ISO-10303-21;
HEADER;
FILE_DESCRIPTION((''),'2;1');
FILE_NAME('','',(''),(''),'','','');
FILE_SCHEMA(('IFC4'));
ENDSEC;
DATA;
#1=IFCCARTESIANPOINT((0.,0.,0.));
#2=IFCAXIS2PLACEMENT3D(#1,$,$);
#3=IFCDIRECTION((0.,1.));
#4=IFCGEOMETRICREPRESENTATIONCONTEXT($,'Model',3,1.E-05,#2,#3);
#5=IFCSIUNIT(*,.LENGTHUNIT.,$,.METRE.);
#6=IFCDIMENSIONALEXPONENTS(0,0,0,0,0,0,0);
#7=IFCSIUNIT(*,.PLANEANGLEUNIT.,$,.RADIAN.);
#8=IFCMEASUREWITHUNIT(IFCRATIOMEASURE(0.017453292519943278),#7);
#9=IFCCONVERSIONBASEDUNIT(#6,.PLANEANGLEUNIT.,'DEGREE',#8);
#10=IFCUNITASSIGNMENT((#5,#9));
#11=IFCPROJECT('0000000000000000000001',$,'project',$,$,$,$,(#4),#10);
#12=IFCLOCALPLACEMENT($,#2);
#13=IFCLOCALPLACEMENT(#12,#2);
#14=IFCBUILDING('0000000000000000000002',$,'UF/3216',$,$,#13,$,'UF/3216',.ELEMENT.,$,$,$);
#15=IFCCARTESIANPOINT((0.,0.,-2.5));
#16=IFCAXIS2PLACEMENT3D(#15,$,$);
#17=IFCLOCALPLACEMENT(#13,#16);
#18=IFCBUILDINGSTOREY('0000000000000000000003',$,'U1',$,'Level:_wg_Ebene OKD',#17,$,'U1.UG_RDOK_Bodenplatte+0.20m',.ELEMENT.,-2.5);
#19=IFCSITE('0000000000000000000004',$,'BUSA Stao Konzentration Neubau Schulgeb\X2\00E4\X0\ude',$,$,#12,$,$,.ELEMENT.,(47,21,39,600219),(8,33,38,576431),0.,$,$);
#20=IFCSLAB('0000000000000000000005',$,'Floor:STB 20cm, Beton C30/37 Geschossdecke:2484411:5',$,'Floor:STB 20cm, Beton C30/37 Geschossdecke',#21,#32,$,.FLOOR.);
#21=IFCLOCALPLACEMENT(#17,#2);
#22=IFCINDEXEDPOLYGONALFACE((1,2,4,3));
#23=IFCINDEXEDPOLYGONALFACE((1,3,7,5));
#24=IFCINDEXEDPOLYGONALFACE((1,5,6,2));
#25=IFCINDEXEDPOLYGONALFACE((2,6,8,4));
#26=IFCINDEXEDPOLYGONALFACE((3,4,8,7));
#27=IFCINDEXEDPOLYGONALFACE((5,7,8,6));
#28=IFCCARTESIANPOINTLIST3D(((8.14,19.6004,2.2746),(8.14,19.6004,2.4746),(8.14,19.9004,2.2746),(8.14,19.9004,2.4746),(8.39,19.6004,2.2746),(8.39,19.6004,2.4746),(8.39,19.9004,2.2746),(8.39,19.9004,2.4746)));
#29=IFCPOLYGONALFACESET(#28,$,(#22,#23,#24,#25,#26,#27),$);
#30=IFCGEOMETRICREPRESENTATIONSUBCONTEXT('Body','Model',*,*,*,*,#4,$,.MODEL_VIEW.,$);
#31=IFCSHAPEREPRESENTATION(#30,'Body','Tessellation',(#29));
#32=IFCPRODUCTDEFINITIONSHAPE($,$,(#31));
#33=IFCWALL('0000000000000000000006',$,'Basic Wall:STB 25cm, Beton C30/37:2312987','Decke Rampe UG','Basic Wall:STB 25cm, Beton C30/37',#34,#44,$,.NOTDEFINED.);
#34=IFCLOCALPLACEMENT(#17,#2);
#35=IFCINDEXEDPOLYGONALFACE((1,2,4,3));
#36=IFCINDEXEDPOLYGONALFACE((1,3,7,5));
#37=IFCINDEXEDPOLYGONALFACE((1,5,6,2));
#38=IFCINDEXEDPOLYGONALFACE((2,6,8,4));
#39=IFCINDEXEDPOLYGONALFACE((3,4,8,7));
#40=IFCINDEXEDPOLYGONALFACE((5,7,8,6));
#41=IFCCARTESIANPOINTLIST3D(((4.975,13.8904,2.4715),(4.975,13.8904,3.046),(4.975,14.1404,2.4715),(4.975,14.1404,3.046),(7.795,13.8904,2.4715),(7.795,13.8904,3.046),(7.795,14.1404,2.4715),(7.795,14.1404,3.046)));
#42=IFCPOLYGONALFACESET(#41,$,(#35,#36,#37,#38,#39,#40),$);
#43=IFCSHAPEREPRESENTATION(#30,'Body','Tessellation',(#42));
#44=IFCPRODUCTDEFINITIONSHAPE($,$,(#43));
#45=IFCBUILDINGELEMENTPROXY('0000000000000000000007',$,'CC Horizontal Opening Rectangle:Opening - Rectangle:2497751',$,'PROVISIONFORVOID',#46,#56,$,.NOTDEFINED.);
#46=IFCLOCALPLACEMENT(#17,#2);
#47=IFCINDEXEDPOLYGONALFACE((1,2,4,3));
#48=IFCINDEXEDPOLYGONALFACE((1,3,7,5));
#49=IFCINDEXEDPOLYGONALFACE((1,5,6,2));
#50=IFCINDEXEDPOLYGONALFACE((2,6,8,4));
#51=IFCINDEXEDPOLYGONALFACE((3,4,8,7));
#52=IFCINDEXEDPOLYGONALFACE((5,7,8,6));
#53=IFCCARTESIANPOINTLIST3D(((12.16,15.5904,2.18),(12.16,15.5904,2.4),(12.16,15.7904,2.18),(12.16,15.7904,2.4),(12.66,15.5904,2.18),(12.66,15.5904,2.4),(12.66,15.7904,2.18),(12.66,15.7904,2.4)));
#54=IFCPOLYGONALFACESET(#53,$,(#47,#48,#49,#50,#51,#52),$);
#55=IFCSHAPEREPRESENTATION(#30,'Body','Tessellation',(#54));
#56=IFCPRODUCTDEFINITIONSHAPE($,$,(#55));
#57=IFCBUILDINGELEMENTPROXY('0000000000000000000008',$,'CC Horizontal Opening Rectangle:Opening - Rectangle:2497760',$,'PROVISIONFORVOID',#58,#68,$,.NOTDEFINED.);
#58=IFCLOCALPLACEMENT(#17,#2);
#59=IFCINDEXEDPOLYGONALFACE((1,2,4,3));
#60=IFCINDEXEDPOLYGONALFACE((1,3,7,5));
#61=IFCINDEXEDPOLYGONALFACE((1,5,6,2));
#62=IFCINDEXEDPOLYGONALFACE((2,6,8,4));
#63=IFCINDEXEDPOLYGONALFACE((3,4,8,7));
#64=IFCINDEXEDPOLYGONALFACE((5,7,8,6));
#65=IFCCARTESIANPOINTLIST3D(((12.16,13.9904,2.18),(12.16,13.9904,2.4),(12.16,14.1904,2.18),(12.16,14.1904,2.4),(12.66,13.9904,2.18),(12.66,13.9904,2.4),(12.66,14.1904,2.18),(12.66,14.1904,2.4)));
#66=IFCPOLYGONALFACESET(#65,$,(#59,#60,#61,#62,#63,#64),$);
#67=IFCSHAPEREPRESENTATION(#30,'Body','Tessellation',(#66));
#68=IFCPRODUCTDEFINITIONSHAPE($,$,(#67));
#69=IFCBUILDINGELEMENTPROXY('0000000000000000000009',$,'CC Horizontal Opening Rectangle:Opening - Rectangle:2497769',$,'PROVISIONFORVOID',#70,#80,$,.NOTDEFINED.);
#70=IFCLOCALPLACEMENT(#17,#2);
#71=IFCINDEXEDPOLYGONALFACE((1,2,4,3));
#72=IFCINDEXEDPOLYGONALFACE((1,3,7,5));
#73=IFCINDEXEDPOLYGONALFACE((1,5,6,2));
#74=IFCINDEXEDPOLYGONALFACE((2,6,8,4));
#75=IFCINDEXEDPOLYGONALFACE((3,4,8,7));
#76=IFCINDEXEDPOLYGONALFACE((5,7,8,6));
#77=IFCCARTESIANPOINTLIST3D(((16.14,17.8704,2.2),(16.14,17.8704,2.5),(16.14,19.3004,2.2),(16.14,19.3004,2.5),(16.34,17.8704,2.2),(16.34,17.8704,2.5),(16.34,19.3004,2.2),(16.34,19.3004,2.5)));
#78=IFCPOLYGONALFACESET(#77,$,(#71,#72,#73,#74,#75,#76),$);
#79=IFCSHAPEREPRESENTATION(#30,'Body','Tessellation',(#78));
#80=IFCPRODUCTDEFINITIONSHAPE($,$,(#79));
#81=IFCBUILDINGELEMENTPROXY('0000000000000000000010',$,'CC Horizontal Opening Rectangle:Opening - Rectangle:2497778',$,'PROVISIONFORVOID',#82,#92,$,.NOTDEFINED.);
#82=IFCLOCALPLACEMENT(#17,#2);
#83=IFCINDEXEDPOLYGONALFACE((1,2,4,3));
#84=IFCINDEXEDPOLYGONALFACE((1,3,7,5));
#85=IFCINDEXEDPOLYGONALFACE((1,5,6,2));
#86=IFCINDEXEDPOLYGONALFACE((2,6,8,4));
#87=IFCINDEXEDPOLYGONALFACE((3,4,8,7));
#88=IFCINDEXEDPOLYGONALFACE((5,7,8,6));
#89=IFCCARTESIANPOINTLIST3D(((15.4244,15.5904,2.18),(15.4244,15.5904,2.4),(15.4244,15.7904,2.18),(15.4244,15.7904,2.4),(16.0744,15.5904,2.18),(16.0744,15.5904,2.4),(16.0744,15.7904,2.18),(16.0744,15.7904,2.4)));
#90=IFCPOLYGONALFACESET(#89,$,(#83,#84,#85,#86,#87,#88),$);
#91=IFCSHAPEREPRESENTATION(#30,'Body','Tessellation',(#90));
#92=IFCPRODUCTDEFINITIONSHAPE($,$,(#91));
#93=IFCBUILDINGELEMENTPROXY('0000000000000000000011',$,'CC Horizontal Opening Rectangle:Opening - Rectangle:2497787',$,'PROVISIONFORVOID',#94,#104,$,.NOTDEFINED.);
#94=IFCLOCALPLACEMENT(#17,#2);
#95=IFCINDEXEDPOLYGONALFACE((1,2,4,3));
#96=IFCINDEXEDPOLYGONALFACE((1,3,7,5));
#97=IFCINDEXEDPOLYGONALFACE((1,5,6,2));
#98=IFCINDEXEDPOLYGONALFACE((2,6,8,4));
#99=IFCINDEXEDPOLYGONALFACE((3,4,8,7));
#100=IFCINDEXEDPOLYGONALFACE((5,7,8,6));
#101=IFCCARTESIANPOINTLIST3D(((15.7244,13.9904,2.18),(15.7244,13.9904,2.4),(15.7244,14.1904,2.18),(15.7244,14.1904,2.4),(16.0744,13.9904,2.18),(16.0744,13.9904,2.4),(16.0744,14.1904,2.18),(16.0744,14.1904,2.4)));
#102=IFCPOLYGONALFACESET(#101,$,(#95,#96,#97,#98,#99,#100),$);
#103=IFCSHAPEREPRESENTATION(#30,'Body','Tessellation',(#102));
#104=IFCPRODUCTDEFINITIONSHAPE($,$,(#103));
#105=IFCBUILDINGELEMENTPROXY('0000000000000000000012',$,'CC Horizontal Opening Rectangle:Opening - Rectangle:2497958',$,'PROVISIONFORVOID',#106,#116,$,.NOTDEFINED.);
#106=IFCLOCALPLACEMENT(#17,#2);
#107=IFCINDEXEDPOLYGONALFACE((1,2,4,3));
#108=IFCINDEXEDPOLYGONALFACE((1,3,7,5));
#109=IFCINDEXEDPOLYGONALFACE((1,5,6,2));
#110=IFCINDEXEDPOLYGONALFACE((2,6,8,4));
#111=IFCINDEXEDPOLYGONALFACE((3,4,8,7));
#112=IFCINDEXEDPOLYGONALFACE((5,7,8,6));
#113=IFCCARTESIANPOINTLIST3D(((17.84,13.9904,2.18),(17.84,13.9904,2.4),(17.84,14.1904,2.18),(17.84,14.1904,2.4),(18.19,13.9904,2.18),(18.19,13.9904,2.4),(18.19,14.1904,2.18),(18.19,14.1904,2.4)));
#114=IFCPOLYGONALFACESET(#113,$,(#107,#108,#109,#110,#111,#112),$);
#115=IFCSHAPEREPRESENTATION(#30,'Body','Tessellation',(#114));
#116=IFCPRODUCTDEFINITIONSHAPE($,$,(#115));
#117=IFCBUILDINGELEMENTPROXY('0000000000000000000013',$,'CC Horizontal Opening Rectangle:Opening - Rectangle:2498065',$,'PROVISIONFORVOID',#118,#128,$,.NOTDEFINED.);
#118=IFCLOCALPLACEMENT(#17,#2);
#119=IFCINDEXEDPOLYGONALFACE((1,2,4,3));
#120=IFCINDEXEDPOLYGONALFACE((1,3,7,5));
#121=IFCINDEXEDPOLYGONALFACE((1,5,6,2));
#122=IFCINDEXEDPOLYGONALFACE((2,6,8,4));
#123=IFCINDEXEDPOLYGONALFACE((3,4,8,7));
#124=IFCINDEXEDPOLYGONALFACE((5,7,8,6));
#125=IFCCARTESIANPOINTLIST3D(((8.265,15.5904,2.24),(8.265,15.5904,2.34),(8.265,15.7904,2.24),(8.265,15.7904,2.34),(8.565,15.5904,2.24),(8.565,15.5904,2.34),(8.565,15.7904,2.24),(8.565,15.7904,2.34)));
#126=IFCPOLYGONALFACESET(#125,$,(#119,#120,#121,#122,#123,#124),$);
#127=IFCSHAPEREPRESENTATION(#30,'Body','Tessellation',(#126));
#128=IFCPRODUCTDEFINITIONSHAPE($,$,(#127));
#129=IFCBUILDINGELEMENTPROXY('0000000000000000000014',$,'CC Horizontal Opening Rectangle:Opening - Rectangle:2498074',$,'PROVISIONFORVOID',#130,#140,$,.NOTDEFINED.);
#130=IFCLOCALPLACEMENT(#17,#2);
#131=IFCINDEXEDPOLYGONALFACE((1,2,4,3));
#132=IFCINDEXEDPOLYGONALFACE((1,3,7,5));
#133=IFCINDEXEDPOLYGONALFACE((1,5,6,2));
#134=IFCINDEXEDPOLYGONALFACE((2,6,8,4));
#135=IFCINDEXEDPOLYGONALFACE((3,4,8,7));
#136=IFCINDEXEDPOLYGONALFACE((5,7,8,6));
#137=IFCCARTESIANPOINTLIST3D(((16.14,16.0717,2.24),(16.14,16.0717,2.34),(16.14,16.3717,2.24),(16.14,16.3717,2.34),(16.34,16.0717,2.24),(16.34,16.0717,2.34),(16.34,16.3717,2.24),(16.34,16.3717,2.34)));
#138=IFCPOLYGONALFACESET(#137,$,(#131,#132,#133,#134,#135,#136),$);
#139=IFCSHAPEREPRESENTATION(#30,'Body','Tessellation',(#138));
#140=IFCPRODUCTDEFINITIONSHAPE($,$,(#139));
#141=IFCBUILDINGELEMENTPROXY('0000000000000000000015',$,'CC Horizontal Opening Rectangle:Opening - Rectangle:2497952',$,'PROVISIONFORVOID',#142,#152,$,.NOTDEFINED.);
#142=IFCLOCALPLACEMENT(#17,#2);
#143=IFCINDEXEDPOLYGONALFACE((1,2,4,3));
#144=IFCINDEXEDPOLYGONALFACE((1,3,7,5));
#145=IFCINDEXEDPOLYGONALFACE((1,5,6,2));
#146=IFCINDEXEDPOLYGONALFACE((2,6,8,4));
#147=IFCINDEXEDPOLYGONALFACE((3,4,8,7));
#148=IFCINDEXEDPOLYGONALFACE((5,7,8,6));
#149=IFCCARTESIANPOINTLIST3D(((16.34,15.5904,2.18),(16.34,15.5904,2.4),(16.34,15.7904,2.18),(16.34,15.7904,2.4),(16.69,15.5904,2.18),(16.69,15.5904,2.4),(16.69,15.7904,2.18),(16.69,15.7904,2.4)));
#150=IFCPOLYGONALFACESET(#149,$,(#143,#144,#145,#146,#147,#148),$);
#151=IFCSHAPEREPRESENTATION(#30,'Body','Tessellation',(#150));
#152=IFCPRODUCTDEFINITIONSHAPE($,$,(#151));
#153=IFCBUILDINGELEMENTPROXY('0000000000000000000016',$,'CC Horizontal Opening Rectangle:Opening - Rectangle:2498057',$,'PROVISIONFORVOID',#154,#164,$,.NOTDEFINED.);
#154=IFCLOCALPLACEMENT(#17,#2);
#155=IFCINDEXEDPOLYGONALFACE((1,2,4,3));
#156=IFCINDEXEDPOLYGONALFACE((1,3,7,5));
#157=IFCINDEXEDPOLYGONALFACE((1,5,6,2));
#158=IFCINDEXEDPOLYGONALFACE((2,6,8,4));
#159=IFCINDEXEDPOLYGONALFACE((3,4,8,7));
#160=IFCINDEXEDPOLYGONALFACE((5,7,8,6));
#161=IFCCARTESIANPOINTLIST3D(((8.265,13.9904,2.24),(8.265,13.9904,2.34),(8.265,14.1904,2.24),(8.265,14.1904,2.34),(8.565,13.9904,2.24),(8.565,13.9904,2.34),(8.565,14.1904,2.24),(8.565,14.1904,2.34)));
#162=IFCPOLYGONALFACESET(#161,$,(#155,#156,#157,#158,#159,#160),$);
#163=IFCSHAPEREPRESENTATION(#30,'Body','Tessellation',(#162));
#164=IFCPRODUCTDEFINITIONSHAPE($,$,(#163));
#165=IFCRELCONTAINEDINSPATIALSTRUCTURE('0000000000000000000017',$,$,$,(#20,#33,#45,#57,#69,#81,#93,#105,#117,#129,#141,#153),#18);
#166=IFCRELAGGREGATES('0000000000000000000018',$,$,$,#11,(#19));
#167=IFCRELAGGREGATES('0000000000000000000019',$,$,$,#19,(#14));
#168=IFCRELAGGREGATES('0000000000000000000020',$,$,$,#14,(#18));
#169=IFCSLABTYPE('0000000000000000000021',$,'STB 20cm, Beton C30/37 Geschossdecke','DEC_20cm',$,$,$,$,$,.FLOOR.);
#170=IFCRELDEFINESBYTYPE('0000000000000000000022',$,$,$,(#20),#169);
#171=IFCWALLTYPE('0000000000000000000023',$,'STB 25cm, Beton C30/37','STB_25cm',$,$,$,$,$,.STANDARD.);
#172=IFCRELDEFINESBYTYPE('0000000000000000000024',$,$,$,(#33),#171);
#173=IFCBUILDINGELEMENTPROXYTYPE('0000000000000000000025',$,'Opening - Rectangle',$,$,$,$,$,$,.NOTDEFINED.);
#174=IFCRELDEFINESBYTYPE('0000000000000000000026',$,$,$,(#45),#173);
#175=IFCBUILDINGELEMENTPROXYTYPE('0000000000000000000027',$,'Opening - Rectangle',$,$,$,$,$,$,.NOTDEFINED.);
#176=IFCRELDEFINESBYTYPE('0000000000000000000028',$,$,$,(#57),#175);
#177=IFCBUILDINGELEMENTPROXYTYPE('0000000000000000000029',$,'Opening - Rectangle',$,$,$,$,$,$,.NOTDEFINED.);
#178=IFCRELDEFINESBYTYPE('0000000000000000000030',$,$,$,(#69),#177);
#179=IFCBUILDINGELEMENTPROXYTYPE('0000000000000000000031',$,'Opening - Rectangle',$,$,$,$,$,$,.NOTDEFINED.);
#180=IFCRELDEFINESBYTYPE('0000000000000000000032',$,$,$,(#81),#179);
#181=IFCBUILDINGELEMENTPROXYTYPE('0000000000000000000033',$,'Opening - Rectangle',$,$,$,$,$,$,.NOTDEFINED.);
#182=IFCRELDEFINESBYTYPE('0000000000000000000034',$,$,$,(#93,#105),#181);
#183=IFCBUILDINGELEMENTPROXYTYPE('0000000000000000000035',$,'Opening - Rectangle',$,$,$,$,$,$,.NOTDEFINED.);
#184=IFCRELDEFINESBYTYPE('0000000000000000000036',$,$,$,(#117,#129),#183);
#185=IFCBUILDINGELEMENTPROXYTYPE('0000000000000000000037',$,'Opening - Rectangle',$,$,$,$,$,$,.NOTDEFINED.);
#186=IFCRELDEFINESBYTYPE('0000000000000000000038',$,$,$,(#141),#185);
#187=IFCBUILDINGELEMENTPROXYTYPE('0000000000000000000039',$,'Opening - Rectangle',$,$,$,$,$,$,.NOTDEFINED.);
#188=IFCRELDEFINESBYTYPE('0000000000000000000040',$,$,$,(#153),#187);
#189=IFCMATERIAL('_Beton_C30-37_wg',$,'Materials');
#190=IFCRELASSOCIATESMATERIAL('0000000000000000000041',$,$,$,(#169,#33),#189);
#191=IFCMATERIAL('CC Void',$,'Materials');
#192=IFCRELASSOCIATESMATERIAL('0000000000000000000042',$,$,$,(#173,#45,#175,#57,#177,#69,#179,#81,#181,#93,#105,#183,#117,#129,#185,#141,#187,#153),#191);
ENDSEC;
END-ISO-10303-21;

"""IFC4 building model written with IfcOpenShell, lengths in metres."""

from ifc_helpers import new_model, entity, si_unit, converted_unit, direction, frame, frame_2d, origin, place, context, subcontext, project, spatial, indexed_curve, rectangle, outline, extrude, source, transform, mapped, material, type_object, type_shapes, element, save


model = new_model("IFC4")

# Units and contexts
model_context = context("Model", 3, precision=1e-05, world=origin(), true_north=direction((0.0, 1.0)))
body_context = subcontext(model_context, "Body", "Model", "MODEL_VIEW")
ifc_project = project(units=[si_unit("LENGTHUNIT", "METRE"), converted_unit("PLANEANGLEUNIT", "DEGREE", entity("IfcRatioMeasure", 0.017453292519943278), si_unit("PLANEANGLEUNIT", "RADIAN"), dimensions=[0, 0, 0, 0, 0, 0, 0])], contexts=[model_context])

# Site, building, storey
site_placement = place(None, origin())
site = spatial("IfcSite", under=ifc_project, at=site_placement, Name="BUSA Stao Konzentration Neubau Schulgebäude", CompositionType="ELEMENT", RefLatitude=(47, 21, 39, 600219), RefLongitude=(8, 33, 38, 576431), RefElevation=0.0)
building_placement = place(site_placement, origin())
building = spatial("IfcBuilding", under=site, at=building_placement, Name="UF/3216", LongName="UF/3216", CompositionType="ELEMENT")
storey_placement = place(building_placement, frame((0.0, 0.0, -2.5)))
storey = spatial("IfcBuildingStorey", under=building, at=storey_placement, Name="U1", ObjectType="Level:_wg_Ebene OKD", LongName="U1.UG_RDOK_Bodenplatte+0.20m", CompositionType="ELEMENT", Elevation=-2.5)

# Slab
ifc_material_1 = material(Name="_Beton_C30-37_wg", Category="Materials")
slab_type = type_object("IfcSlabType", Name="STB 20cm, Beton C30/37 Geschossdecke", Description="DEC_20cm", PredefinedType="FLOOR", material=ifc_material_1)
slab_1_placement = place(storey_placement, frame((8.14, 19.6004, 2.2746)))
element("IfcSlab", 1, at=slab_1_placement, inside=storey, type_object=slab_type, Name="Floor:STB 20cm, Beton C30/37 Geschossdecke:2484411:5", ObjectType="Floor:STB 20cm, Beton C30/37 Geschossdecke", PredefinedType="FLOOR", context=body_context, shape_type="SweptSolid", body=[
    extrude(rectangle(XDim=0.3, YDim=0.25, at=frame_2d((27.45, 0.0), x_axis=(0.0, -1.0))), frame((27.575, 0.15, 0.2), z_axis=(0.0, 0.0, -1.0), x_axis=(-1.0, 0.0, 0.0)), (0.0, 0.0, 1.0), 0.2),
])

# Wall
wall_type = type_object("IfcWallType", Name="STB 25cm, Beton C30/37", Description="STB_25cm", PredefinedType="STANDARD")
wall_placement = place(storey_placement, frame((7.795, 14.0154, 2.4715), z_axis=(0.0, 0.0, 1.0), x_axis=(-1.0, 0.0, 0.0)))
element("IfcWall", 2, at=wall_placement, inside=storey, type_object=wall_type, material=ifc_material_1, Name="Basic Wall:STB 25cm, Beton C30/37:2312987", Description="Decke Rampe UG", ObjectType="Basic Wall:STB 25cm, Beton C30/37", PredefinedType="NOTDEFINED", context=body_context, shape_type="SweptSolid", body=[
    extrude(outline(indexed_curve([(2.82, 0.125), (0.0, 0.125), (0.0, -0.125), (2.82, -0.125), (2.82, 0.125)], self_intersect=False)), origin(), (0.0, 0.0, 1.0), 0.5746),
])

# Building element proxies
ifc_material_2 = material(Name="CC Void", Category="Materials")
building_element_proxy_type_1 = type_object("IfcBuildingElementProxyType", Name="Opening - Rectangle", PredefinedType="NOTDEFINED", material=ifc_material_2)
shared_shape_1 = source(origin(), body_context, "Body", "SweptSolid", [
    extrude(outline(indexed_curve([(-0.1, -0.25), (0.1, -0.25), (0.1, 0.25), (-0.1, 0.25), (-0.1, -0.25)], self_intersect=False)), frame((0.0, 0.0, -0.32), z_axis=(0.0, 0.0, 1.0), x_axis=(0.0, -1.0, 0.0)), (0.0, 0.0, 1.0), 0.22),
])
type_shapes(building_element_proxy_type_1, [shared_shape_1])
proxy_1_placement = place(storey_placement, frame((12.41, 15.6904, 2.5)))
element("IfcBuildingElementProxy", 3, at=proxy_1_placement, inside=storey, type_object=building_element_proxy_type_1, material=ifc_material_2, Name="CC Horizontal Opening Rectangle:Opening - Rectangle:2497751", ObjectType="PROVISIONFORVOID", PredefinedType="NOTDEFINED", context=body_context, shape_type="MappedRepresentation", body=[
    mapped(shared_shape_1, transform((0.0, 0.0, 0.0), scale=1.0)),
])
building_element_proxy_type_2 = type_object("IfcBuildingElementProxyType", Name="Opening - Rectangle", PredefinedType="NOTDEFINED", material=ifc_material_2)
shared_shape_2 = source(origin(), body_context, "Body", "SweptSolid", [
    extrude(outline(indexed_curve([(-0.1, -0.25), (0.1, -0.25), (0.1, 0.25), (-0.1, 0.25), (-0.1, -0.25)], self_intersect=False)), frame((0.0, 0.0, -0.32), z_axis=(0.0, 0.0, 1.0), x_axis=(0.0, -1.0, 0.0)), (0.0, 0.0, 1.0), 0.22),
])
type_shapes(building_element_proxy_type_2, [shared_shape_2])
proxy_2_placement = place(storey_placement, frame((12.41, 14.0904, 2.5)))
element("IfcBuildingElementProxy", 4, at=proxy_2_placement, inside=storey, type_object=building_element_proxy_type_2, material=ifc_material_2, Name="CC Horizontal Opening Rectangle:Opening - Rectangle:2497760", ObjectType="PROVISIONFORVOID", PredefinedType="NOTDEFINED", context=body_context, shape_type="MappedRepresentation", body=[
    mapped(shared_shape_2, transform((0.0, 0.0, 0.0), scale=1.0)),
])
building_element_proxy_type_3 = type_object("IfcBuildingElementProxyType", Name="Opening - Rectangle", PredefinedType="NOTDEFINED", material=ifc_material_2)
shared_shape_3 = source(origin(), body_context, "Body", "SweptSolid", [
    extrude(outline(indexed_curve([(-0.1, -0.715), (0.1, -0.715), (0.1, 0.715), (-0.1, 0.715), (-0.1, -0.715)], self_intersect=False)), frame((0.0, 0.0, -0.3), z_axis=(0.0, 0.0, 1.0), x_axis=(0.0, -1.0, 0.0)), (0.0, 0.0, 1.0), 0.3),
])
type_shapes(building_element_proxy_type_3, [shared_shape_3])
proxy_3_placement = place(storey_placement, frame((16.24, 18.5854, 2.5), z_axis=(0.0, 0.0, 1.0), x_axis=(0.0, 1.0, 0.0)))
element("IfcBuildingElementProxy", 5, at=proxy_3_placement, inside=storey, type_object=building_element_proxy_type_3, material=ifc_material_2, Name="CC Horizontal Opening Rectangle:Opening - Rectangle:2497769", ObjectType="PROVISIONFORVOID", PredefinedType="NOTDEFINED", context=body_context, shape_type="MappedRepresentation", body=[
    mapped(shared_shape_3, transform((0.0, 0.0, 0.0), scale=1.0)),
])
building_element_proxy_type_4 = type_object("IfcBuildingElementProxyType", Name="Opening - Rectangle", PredefinedType="NOTDEFINED", material=ifc_material_2)
shared_shape_4 = source(origin(), body_context, "Body", "SweptSolid", [
    extrude(outline(indexed_curve([(-0.1, -0.325), (0.1, -0.325), (0.1, 0.325), (-0.1, 0.325), (-0.1, -0.325)], self_intersect=False)), frame((0.0, 0.0, -0.32), z_axis=(0.0, 0.0, 1.0), x_axis=(0.0, -1.0, 0.0)), (0.0, 0.0, 1.0), 0.22),
])
type_shapes(building_element_proxy_type_4, [shared_shape_4])
proxy_4_placement = place(storey_placement, frame((15.7494, 15.6904, 2.5)))
element("IfcBuildingElementProxy", 6, at=proxy_4_placement, inside=storey, type_object=building_element_proxy_type_4, material=ifc_material_2, Name="CC Horizontal Opening Rectangle:Opening - Rectangle:2497778", ObjectType="PROVISIONFORVOID", PredefinedType="NOTDEFINED", context=body_context, shape_type="MappedRepresentation", body=[
    mapped(shared_shape_4, transform((0.0, 0.0, 0.0), scale=1.0)),
])
building_element_proxy_type_5 = type_object("IfcBuildingElementProxyType", Name="Opening - Rectangle", PredefinedType="NOTDEFINED", material=ifc_material_2)
shared_shape_5 = source(origin(), body_context, "Body", "SweptSolid", [
    extrude(outline(indexed_curve([(-0.1, -0.175), (0.1, -0.175), (0.1, 0.175), (-0.1, 0.175), (-0.1, -0.175)], self_intersect=False)), frame((0.0, 0.0, -0.32), z_axis=(0.0, 0.0, 1.0), x_axis=(0.0, -1.0, 0.0)), (0.0, 0.0, 1.0), 0.22),
])
type_shapes(building_element_proxy_type_5, [shared_shape_5])
for number, where, name in (
    (7, (15.8994, 14.0904, 2.5), "CC Horizontal Opening Rectangle:Opening - Rectangle:2497787"),
    (8, (18.015, 14.0904, 2.5), "CC Horizontal Opening Rectangle:Opening - Rectangle:2497958"),
):
    element("IfcBuildingElementProxy", number, at=place(storey_placement, frame(where)), inside=storey, type_object=building_element_proxy_type_5, material=ifc_material_2, Name=name, ObjectType="PROVISIONFORVOID", PredefinedType="NOTDEFINED", context=body_context, shape_type="MappedRepresentation", body=[
        mapped(shared_shape_5, transform((0.0, 0.0, 0.0), scale=1.0)),
    ])
building_element_proxy_type_6 = type_object("IfcBuildingElementProxyType", Name="Opening - Rectangle", PredefinedType="NOTDEFINED", material=ifc_material_2)
shared_shape_6 = source(origin(), body_context, "Body", "SweptSolid", [
    extrude(outline(indexed_curve([(-0.1, -0.15), (0.1, -0.15), (0.1, 0.15), (-0.1, 0.15), (-0.1, -0.15)], self_intersect=False)), frame((0.0, 0.0, -0.26), z_axis=(0.0, 0.0, 1.0), x_axis=(0.0, -1.0, 0.0)), (0.0, 0.0, 1.0), 0.1),
])
type_shapes(building_element_proxy_type_6, [shared_shape_6])
proxy_5_placement = place(storey_placement, frame((8.415, 15.6904, 2.5)))
element("IfcBuildingElementProxy", 9, at=proxy_5_placement, inside=storey, type_object=building_element_proxy_type_6, material=ifc_material_2, Name="CC Horizontal Opening Rectangle:Opening - Rectangle:2498065", ObjectType="PROVISIONFORVOID", PredefinedType="NOTDEFINED", context=body_context, shape_type="MappedRepresentation", body=[
    mapped(shared_shape_6, transform((0.0, 0.0, 0.0), scale=1.0)),
])
proxy_6_placement = place(storey_placement, frame((16.24, 16.2217, 2.5), z_axis=(0.0, 0.0, 1.0), x_axis=(0.0, 1.0, 0.0)))
element("IfcBuildingElementProxy", 10, at=proxy_6_placement, inside=storey, type_object=building_element_proxy_type_6, material=ifc_material_2, Name="CC Horizontal Opening Rectangle:Opening - Rectangle:2498074", ObjectType="PROVISIONFORVOID", PredefinedType="NOTDEFINED", context=body_context, shape_type="MappedRepresentation", body=[
    mapped(shared_shape_6, transform((0.0, 0.0, 0.0), scale=1.0)),
])
building_element_proxy_type_7 = type_object("IfcBuildingElementProxyType", Name="Opening - Rectangle", PredefinedType="NOTDEFINED", material=ifc_material_2)
shared_shape_7 = source(origin(), body_context, "Body", "SweptSolid", [
    extrude(outline(indexed_curve([(-0.1, -0.175), (0.1, -0.175), (0.1, 0.175), (-0.1, 0.175), (-0.1, -0.175)], self_intersect=False)), frame((0.0, 0.0, -0.32), z_axis=(0.0, 0.0, 1.0), x_axis=(0.0, -1.0, 0.0)), (0.0, 0.0, 1.0), 0.22),
])
type_shapes(building_element_proxy_type_7, [shared_shape_7])
proxy_7_placement = place(storey_placement, frame((16.515, 15.6904, 2.5)))
element("IfcBuildingElementProxy", 11, at=proxy_7_placement, inside=storey, type_object=building_element_proxy_type_7, material=ifc_material_2, Name="CC Horizontal Opening Rectangle:Opening - Rectangle:2497952", ObjectType="PROVISIONFORVOID", PredefinedType="NOTDEFINED", context=body_context, shape_type="MappedRepresentation", body=[
    mapped(shared_shape_7, transform((0.0, 0.0, 0.0), scale=1.0)),
])
building_element_proxy_type_8 = type_object("IfcBuildingElementProxyType", Name="Opening - Rectangle", PredefinedType="NOTDEFINED", material=ifc_material_2)
shared_shape_8 = source(origin(), body_context, "Body", "SweptSolid", [
    extrude(outline(indexed_curve([(-0.1, -0.15), (0.1, -0.15), (0.1, 0.15), (-0.1, 0.15), (-0.1, -0.15)], self_intersect=False)), frame((0.0, 0.0, -0.26), z_axis=(0.0, 0.0, 1.0), x_axis=(0.0, -1.0, 0.0)), (0.0, 0.0, 1.0), 0.1),
])
type_shapes(building_element_proxy_type_8, [shared_shape_8])
proxy_8_placement = place(storey_placement, frame((8.415, 14.0904, 2.5)))
element("IfcBuildingElementProxy", 12, at=proxy_8_placement, inside=storey, type_object=building_element_proxy_type_8, material=ifc_material_2, Name="CC Horizontal Opening Rectangle:Opening - Rectangle:2498057", ObjectType="PROVISIONFORVOID", PredefinedType="NOTDEFINED", context=body_context, shape_type="MappedRepresentation", body=[
    mapped(shared_shape_8, transform((0.0, 0.0, 0.0), scale=1.0)),
])

save(model, "model.ifc")
